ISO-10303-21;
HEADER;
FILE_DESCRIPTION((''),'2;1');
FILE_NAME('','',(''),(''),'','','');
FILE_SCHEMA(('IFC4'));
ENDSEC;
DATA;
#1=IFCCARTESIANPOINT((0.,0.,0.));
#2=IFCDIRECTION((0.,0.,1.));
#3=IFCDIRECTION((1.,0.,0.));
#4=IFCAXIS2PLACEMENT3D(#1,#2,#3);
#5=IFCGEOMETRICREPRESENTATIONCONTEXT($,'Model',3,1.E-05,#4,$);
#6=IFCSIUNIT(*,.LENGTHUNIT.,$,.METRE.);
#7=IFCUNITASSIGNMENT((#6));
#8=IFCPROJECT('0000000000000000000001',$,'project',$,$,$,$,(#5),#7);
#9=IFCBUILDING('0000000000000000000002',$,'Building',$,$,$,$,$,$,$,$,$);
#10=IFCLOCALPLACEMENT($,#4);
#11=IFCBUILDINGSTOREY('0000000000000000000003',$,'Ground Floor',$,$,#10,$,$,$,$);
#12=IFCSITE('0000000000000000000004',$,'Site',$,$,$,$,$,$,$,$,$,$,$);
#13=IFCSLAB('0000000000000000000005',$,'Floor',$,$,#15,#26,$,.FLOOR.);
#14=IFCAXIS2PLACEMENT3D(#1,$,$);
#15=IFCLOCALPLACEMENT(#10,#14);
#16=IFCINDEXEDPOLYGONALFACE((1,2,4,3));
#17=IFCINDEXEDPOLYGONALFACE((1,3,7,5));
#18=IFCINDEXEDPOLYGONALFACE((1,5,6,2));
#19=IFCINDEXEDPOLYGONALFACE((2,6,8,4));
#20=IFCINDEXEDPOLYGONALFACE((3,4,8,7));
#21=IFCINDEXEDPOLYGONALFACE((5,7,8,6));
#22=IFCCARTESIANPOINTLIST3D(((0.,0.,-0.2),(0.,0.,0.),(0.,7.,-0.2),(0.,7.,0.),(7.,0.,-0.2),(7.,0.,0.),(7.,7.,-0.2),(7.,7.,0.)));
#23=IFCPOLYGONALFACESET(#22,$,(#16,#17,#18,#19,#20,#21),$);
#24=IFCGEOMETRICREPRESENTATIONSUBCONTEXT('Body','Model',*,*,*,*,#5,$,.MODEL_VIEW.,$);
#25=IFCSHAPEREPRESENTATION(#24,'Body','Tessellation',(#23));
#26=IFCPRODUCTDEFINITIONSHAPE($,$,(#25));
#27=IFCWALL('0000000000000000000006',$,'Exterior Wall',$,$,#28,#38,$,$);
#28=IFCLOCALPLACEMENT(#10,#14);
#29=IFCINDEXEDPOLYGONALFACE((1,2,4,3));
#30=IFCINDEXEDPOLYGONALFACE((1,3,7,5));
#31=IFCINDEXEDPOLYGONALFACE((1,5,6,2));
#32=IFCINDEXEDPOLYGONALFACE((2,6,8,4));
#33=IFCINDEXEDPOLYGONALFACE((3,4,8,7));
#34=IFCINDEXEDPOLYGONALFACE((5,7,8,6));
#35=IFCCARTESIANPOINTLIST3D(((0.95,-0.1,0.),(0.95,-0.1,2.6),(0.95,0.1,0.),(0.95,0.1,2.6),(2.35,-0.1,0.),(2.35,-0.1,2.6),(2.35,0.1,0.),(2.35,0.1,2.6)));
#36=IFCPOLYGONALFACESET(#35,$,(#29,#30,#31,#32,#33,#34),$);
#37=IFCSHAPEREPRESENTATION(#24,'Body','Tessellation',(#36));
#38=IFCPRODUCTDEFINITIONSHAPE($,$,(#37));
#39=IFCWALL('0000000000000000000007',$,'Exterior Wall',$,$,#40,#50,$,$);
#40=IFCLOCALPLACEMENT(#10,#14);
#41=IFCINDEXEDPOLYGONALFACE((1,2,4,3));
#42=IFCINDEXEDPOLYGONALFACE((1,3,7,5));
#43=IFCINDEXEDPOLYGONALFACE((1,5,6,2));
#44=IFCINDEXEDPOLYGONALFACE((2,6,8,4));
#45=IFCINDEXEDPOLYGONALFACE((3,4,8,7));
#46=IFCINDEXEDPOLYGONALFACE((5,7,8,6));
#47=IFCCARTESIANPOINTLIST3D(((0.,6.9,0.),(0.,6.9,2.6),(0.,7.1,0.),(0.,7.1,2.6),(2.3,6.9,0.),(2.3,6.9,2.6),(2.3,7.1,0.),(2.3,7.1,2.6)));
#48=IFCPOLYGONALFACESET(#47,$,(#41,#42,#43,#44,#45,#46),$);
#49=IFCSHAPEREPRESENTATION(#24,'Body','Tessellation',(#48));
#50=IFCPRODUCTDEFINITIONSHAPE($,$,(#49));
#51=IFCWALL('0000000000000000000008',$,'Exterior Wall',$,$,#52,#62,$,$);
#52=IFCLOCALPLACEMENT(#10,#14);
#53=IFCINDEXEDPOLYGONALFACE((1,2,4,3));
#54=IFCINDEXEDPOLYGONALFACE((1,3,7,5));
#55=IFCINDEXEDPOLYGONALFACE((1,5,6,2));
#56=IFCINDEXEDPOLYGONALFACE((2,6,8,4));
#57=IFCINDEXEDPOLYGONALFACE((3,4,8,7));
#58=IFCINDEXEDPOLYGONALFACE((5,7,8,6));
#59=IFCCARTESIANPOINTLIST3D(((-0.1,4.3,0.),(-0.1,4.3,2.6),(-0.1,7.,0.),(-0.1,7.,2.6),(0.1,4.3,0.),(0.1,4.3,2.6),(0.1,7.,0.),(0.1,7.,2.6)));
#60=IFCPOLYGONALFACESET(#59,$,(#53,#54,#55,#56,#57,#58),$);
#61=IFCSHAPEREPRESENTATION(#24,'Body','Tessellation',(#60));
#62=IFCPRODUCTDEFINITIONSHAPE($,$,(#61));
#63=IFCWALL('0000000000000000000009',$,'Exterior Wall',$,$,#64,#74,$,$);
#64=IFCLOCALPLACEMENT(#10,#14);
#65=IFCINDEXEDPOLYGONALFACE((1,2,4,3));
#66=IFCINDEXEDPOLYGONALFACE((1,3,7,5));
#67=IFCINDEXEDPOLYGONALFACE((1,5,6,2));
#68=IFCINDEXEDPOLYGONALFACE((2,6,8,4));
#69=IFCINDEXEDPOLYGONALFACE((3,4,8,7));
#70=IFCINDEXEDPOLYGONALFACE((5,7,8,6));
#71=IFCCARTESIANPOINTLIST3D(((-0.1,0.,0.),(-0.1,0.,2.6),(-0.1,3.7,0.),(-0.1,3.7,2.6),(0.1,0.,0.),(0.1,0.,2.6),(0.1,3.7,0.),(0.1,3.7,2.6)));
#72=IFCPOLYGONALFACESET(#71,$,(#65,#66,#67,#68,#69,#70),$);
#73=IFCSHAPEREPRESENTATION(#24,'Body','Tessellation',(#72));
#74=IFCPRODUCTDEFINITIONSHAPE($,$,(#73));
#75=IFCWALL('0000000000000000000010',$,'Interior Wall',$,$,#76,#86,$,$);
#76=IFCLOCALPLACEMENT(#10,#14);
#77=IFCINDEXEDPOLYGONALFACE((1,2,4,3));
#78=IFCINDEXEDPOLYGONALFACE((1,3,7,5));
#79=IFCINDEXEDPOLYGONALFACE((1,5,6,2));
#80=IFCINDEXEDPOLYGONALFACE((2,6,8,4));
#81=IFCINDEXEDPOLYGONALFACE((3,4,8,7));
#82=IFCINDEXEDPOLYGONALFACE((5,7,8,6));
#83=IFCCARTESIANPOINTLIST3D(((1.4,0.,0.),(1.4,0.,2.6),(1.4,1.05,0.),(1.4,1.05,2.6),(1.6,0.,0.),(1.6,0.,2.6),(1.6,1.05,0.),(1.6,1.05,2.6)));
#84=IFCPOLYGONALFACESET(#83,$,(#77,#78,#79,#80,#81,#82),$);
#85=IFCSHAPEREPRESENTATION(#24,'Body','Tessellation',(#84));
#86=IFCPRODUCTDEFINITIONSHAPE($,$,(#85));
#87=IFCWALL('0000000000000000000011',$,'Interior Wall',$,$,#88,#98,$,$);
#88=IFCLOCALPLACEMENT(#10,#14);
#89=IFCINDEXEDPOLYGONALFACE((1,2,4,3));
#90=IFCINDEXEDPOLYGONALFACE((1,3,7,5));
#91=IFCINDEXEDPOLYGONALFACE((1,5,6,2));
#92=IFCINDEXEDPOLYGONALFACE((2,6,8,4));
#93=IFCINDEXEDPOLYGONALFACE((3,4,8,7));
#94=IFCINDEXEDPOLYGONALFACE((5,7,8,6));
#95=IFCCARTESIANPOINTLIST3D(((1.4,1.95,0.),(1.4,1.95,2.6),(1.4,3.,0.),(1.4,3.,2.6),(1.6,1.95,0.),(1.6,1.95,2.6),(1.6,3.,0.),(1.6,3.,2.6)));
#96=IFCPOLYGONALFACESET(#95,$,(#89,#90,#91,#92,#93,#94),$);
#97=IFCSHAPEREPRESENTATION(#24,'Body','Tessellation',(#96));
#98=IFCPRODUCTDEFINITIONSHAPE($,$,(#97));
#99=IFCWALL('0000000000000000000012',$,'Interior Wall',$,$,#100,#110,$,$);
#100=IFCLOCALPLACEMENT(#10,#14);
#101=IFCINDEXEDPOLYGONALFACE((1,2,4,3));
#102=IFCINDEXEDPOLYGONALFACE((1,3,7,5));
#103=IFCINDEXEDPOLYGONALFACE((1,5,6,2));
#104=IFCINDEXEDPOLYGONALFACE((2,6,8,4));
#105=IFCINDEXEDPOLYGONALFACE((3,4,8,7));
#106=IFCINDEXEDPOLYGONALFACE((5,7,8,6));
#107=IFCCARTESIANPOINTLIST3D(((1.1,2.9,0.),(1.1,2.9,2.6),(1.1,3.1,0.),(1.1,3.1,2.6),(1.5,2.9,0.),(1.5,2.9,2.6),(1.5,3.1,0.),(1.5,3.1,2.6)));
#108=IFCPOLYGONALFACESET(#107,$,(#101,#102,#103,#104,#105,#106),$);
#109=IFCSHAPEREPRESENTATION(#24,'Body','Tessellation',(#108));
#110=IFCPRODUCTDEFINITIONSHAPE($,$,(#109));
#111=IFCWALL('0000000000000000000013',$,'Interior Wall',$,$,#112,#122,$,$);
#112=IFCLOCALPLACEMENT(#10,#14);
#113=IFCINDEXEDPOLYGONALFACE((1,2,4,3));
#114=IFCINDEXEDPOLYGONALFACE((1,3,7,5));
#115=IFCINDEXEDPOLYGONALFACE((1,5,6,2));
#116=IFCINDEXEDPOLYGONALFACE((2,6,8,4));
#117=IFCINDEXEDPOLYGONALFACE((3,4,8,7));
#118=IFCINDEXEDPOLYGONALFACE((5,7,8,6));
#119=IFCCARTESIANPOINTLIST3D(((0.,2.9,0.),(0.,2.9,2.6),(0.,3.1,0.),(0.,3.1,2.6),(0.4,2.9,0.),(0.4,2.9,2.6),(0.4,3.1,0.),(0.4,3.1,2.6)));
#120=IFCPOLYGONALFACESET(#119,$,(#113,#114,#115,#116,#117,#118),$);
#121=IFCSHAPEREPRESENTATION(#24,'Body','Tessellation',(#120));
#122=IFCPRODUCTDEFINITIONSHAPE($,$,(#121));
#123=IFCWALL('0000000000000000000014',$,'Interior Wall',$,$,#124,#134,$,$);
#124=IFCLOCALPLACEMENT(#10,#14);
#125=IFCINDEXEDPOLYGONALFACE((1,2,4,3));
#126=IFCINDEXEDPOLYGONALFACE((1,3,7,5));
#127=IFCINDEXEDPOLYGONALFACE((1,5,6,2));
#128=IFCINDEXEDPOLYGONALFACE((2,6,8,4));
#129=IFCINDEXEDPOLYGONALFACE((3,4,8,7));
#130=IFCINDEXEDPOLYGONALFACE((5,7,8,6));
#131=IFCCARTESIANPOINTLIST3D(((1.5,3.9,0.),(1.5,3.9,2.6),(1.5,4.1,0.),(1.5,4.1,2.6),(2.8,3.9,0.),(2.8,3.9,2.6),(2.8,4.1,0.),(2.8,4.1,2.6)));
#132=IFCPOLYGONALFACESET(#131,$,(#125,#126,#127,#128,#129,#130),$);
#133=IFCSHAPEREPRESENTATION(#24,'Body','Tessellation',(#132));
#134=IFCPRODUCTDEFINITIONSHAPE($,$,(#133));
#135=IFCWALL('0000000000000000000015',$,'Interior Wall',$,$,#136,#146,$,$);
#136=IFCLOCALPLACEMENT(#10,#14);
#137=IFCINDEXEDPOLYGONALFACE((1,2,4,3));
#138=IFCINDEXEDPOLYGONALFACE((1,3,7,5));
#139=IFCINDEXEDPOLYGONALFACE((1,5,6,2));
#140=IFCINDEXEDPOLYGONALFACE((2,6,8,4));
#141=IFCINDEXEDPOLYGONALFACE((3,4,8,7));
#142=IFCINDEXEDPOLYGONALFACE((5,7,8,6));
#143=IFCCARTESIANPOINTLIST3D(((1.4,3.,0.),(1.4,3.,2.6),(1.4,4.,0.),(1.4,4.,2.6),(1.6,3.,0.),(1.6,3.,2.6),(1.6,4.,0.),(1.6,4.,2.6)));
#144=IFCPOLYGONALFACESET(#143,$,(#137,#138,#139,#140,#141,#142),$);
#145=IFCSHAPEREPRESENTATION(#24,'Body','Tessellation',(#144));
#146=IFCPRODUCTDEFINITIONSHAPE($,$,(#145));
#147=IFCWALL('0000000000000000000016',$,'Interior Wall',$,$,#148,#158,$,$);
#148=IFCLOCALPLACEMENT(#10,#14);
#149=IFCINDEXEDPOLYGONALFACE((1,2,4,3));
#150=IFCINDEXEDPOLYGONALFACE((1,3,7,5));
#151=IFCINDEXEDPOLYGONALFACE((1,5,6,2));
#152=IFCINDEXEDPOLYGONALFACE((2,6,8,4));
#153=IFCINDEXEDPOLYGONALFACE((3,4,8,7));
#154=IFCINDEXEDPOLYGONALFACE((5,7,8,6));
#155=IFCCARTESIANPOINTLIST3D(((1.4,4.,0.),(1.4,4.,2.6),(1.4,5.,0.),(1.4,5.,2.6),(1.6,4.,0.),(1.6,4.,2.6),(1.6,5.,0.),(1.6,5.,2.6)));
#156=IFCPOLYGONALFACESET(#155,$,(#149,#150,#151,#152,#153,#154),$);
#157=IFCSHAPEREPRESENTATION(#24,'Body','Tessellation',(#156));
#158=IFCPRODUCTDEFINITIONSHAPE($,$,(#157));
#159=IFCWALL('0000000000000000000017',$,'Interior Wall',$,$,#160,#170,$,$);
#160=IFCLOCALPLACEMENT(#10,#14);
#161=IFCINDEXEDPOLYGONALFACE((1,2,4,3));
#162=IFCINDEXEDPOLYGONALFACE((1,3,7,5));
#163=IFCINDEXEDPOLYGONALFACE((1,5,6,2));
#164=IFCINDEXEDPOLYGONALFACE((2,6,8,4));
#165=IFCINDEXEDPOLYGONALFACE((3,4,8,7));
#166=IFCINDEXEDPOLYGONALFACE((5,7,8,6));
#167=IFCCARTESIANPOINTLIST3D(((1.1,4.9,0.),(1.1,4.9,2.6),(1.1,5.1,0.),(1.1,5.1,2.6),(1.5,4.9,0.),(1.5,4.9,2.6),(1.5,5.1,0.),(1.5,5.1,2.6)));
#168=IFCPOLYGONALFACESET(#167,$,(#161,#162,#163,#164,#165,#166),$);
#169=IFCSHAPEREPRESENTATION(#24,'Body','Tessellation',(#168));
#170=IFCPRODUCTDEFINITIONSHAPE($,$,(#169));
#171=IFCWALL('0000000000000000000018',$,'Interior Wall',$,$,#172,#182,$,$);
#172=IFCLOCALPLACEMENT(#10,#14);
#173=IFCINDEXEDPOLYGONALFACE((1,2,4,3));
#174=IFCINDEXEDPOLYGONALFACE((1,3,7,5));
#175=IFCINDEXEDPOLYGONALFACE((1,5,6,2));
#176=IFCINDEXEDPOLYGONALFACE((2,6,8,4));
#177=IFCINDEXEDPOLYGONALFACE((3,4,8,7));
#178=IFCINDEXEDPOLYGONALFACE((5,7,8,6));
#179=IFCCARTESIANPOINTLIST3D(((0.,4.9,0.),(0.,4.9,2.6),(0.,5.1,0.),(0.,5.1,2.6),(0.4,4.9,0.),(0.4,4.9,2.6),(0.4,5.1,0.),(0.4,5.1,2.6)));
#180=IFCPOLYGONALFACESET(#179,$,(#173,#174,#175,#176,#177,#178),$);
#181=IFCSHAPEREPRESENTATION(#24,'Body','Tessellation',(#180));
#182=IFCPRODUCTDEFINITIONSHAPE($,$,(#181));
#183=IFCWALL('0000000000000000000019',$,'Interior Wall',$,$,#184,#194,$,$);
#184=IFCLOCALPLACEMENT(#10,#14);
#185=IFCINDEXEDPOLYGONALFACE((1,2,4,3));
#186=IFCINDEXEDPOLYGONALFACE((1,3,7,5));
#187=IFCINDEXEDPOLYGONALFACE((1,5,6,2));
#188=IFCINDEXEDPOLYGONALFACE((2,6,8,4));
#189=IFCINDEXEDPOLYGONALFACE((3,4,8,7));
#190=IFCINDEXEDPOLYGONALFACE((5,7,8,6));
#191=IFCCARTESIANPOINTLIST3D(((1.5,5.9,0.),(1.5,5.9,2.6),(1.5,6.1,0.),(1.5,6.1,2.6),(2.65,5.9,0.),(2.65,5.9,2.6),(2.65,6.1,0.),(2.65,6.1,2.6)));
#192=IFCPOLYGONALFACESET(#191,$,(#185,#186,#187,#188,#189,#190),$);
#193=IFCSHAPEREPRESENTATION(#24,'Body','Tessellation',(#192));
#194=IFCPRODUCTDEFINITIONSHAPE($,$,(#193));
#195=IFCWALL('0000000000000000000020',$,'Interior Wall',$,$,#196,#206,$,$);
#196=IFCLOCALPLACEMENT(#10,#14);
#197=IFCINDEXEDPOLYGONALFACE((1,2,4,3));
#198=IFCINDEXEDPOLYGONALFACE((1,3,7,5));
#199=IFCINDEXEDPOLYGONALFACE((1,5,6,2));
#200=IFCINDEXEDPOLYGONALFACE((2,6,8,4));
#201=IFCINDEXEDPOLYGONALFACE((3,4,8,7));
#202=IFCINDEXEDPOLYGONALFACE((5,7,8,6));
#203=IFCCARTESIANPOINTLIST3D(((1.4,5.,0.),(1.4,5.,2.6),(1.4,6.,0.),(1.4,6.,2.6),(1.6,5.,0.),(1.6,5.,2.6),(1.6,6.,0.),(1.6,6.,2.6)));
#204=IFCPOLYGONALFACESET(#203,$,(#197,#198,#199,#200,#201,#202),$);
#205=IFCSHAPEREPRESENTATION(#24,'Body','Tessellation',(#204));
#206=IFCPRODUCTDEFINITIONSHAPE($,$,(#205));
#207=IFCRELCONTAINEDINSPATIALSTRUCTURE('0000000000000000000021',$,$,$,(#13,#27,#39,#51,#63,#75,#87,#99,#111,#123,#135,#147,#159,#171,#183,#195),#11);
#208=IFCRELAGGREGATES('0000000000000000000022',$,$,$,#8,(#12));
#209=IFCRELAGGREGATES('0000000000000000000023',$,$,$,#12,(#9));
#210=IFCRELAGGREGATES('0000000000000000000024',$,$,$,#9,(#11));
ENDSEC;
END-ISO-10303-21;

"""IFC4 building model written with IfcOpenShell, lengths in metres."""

from ifc_helpers import new_model, si_unit, frame, origin_with_axes, place, context, subcontext, project, spatial, indexed_curve, outline, extrude, element, save


model = new_model("IFC4")

# Units and contexts
model_context = context("Model", 3, precision=1e-05, world=origin_with_axes())
body_context = subcontext(model_context, "Body", "Model", "MODEL_VIEW")
ifc_project = project(units=[si_unit("LENGTHUNIT", "METRE")], contexts=[model_context])

# Site, building, storey
site = spatial("IfcSite", under=ifc_project, Name="Site")
building = spatial("IfcBuilding", under=site, Name="Building")
storey_placement = place(None, origin_with_axes())
storey = spatial("IfcBuildingStorey", under=building, at=storey_placement, Name="Ground Floor")

# Slab
slab_placement = place(storey_placement, frame((0.0, 0.0, -0.2), z_axis=(0.0, 0.0, 1.0), x_axis=(1.0, 0.0, 0.0)))
element("IfcSlab", 1, at=slab_placement, inside=storey, Name="Floor", PredefinedType="FLOOR", context=body_context, shape_type="SweptSolid", body=[
    extrude(outline(indexed_curve([(0.0, 0.0), (7.0, 0.0), (7.0, 7.0), (0.0, 7.0)])), None, (0.0, 0.0, 1.0), 0.2),
])

# Walls
wall_1_placement = place(storey_placement, frame((0.95, 0.0, 0.0), z_axis=(0.0, 0.0, 1.0), x_axis=(1.0, 0.0, 0.0)))
element("IfcWall", 2, at=wall_1_placement, inside=storey, Name="Exterior Wall", context=body_context, shape_type="SweptSolid", body=[
    extrude(outline(indexed_curve([(0.0, 0.0), (0.0, 0.2), (1.4, 0.2), (1.4, 0.0), (0.0, 0.0)], self_intersect=False)), frame((0.0, -0.1, 0.0), z_axis=(0.0, 0.0, 1.0), x_axis=(1.0, 0.0, 0.0)), (0.0, 0.0, 1.0), 2.6),
])
wall_2_placement = place(storey_placement, frame((2.3, 7.0, 0.0), z_axis=(0.0, 0.0, 1.0), x_axis=(-1.0, 0.0, 0.0)))
element("IfcWall", 3, at=wall_2_placement, inside=storey, Name="Exterior Wall", context=body_context, shape_type="SweptSolid", body=[
    extrude(outline(indexed_curve([(0.0, 0.0), (0.0, 0.2), (2.3, 0.2), (2.3, 0.0), (0.0, 0.0)], self_intersect=False)), frame((0.0, -0.1, 0.0), z_axis=(0.0, 0.0, 1.0), x_axis=(1.0, 0.0, 0.0)), (0.0, 0.0, 1.0), 2.6),
])
wall_3_placement = place(storey_placement, frame((0.0, 7.0, 0.0), z_axis=(0.0, 0.0, 1.0), x_axis=(0.0, -1.0, 0.0)))
element("IfcWall", 4, at=wall_3_placement, inside=storey, Name="Exterior Wall", context=body_context, shape_type="SweptSolid", body=[
    extrude(outline(indexed_curve([(0.0, 0.0), (0.0, 0.2), (2.7, 0.2), (2.7, 0.0), (0.0, 0.0)], self_intersect=False)), frame((0.0, -0.1, 0.0), z_axis=(0.0, 0.0, 1.0), x_axis=(1.0, 0.0, 0.0)), (0.0, 0.0, 1.0), 2.6),
])
wall_4_placement = place(storey_placement, frame((0.0, 3.7, 0.0), z_axis=(0.0, 0.0, 1.0), x_axis=(0.0, -1.0, 0.0)))
element("IfcWall", 5, at=wall_4_placement, inside=storey, Name="Exterior Wall", context=body_context, shape_type="SweptSolid", body=[
    extrude(outline(indexed_curve([(0.0, 0.0), (0.0, 0.2), (3.7, 0.2), (3.7, 0.0), (0.0, 0.0)], self_intersect=False)), frame((0.0, -0.1, 0.0), z_axis=(0.0, 0.0, 1.0), x_axis=(1.0, 0.0, 0.0)), (0.0, 0.0, 1.0), 2.6),
])
for number, where, z_axis, x_axis, name in (
    (6, (1.5, 0.0, 0.0), (0.0, 0.0, 1.0), (0.0, 1.0, 0.0), "Interior Wall"),
    (7, (1.5, 1.95, 0.0), (0.0, 0.0, 1.0), (0.0, 1.0, 0.0), "Interior Wall"),
):
    element("IfcWall", number, at=place(storey_placement, frame(where, z_axis=z_axis, x_axis=x_axis)), inside=storey, Name=name, context=body_context, shape_type="SweptSolid", body=[
        extrude(outline(indexed_curve([(0.0, 0.0), (0.0, 0.2), (1.05, 0.2), (1.05, 0.0), (0.0, 0.0)], self_intersect=False)), frame((0.0, -0.1, 0.0), z_axis=(0.0, 0.0, 1.0), x_axis=(1.0, 0.0, 0.0)), (0.0, 0.0, 1.0), 2.6),
    ])
for number, where, z_axis, x_axis, name in (
    (8, (1.5, 3.0, 0.0), (0.0, 0.0, 1.0), (-1.0, 0.0, 0.0), "Interior Wall"),
    (9, (0.4, 3.0, 0.0), (0.0, 0.0, 1.0), (-1.0, 0.0, 0.0), "Interior Wall"),
):
    element("IfcWall", number, at=place(storey_placement, frame(where, z_axis=z_axis, x_axis=x_axis)), inside=storey, Name=name, context=body_context, shape_type="SweptSolid", body=[
        extrude(outline(indexed_curve([(0.0, 0.0), (0.0, 0.2), (0.4, 0.2), (0.4, 0.0), (0.0, 0.0)], self_intersect=False)), frame((0.0, -0.1, 0.0), z_axis=(0.0, 0.0, 1.0), x_axis=(1.0, 0.0, 0.0)), (0.0, 0.0, 1.0), 2.6),
    ])
wall_5_placement = place(storey_placement, frame((2.8, 4.0, 0.0), z_axis=(0.0, 0.0, 1.0), x_axis=(-1.0, 0.0, 0.0)))
element("IfcWall", 10, at=wall_5_placement, inside=storey, Name="Interior Wall", context=body_context, shape_type="SweptSolid", body=[
    extrude(outline(indexed_curve([(0.0, 0.0), (0.0, 0.2), (1.3, 0.2), (1.3, 0.0), (0.0, 0.0)], self_intersect=False)), frame((0.0, -0.1, 0.0), z_axis=(0.0, 0.0, 1.0), x_axis=(1.0, 0.0, 0.0)), (0.0, 0.0, 1.0), 2.6),
])
for number, where, z_axis, x_axis, name in (
    (11, (1.5, 4.0, 0.0), (0.0, 0.0, 1.0), (0.0, -1.0, 0.0), "Interior Wall"),
    (12, (1.5, 4.0, 0.0), (0.0, 0.0, 1.0), (0.0, 1.0, 0.0), "Interior Wall"),
):
    element("IfcWall", number, at=place(storey_placement, frame(where, z_axis=z_axis, x_axis=x_axis)), inside=storey, Name=name, context=body_context, shape_type="SweptSolid", body=[
        extrude(outline(indexed_curve([(0.0, 0.0), (0.0, 0.2), (1.0, 0.2), (1.0, 0.0), (0.0, 0.0)], self_intersect=False)), frame((0.0, -0.1, 0.0), z_axis=(0.0, 0.0, 1.0), x_axis=(1.0, 0.0, 0.0)), (0.0, 0.0, 1.0), 2.6),
    ])
for number, where, z_axis, x_axis, name in (
    (13, (1.5, 5.0, 0.0), (0.0, 0.0, 1.0), (-1.0, 0.0, 0.0), "Interior Wall"),
    (14, (0.4, 5.0, 0.0), (0.0, 0.0, 1.0), (-1.0, 0.0, 0.0), "Interior Wall"),
):
    element("IfcWall", number, at=place(storey_placement, frame(where, z_axis=z_axis, x_axis=x_axis)), inside=storey, Name=name, context=body_context, shape_type="SweptSolid", body=[
        extrude(outline(indexed_curve([(0.0, 0.0), (0.0, 0.2), (0.4, 0.2), (0.4, 0.0), (0.0, 0.0)], self_intersect=False)), frame((0.0, -0.1, 0.0), z_axis=(0.0, 0.0, 1.0), x_axis=(1.0, 0.0, 0.0)), (0.0, 0.0, 1.0), 2.6),
    ])
wall_6_placement = place(storey_placement, frame((2.65, 6.0, 0.0), z_axis=(0.0, 0.0, 1.0), x_axis=(-1.0, 0.0, 0.0)))
element("IfcWall", 15, at=wall_6_placement, inside=storey, Name="Interior Wall", context=body_context, shape_type="SweptSolid", body=[
    extrude(outline(indexed_curve([(0.0, 0.0), (0.0, 0.2), (1.15, 0.2), (1.15, 0.0), (0.0, 0.0)], self_intersect=False)), frame((0.0, -0.1, 0.0), z_axis=(0.0, 0.0, 1.0), x_axis=(1.0, 0.0, 0.0)), (0.0, 0.0, 1.0), 2.6),
])
wall_7_placement = place(storey_placement, frame((1.5, 6.0, 0.0), z_axis=(0.0, 0.0, 1.0), x_axis=(0.0, -1.0, 0.0)))
element("IfcWall", 16, at=wall_7_placement, inside=storey, Name="Interior Wall", context=body_context, shape_type="SweptSolid", body=[
    extrude(outline(indexed_curve([(0.0, 0.0), (0.0, 0.2), (1.0, 0.2), (1.0, 0.0), (0.0, 0.0)], self_intersect=False)), frame((0.0, -0.1, 0.0), z_axis=(0.0, 0.0, 1.0), x_axis=(1.0, 0.0, 0.0)), (0.0, 0.0, 1.0), 2.6),
])

save(model, "model.ifc")
